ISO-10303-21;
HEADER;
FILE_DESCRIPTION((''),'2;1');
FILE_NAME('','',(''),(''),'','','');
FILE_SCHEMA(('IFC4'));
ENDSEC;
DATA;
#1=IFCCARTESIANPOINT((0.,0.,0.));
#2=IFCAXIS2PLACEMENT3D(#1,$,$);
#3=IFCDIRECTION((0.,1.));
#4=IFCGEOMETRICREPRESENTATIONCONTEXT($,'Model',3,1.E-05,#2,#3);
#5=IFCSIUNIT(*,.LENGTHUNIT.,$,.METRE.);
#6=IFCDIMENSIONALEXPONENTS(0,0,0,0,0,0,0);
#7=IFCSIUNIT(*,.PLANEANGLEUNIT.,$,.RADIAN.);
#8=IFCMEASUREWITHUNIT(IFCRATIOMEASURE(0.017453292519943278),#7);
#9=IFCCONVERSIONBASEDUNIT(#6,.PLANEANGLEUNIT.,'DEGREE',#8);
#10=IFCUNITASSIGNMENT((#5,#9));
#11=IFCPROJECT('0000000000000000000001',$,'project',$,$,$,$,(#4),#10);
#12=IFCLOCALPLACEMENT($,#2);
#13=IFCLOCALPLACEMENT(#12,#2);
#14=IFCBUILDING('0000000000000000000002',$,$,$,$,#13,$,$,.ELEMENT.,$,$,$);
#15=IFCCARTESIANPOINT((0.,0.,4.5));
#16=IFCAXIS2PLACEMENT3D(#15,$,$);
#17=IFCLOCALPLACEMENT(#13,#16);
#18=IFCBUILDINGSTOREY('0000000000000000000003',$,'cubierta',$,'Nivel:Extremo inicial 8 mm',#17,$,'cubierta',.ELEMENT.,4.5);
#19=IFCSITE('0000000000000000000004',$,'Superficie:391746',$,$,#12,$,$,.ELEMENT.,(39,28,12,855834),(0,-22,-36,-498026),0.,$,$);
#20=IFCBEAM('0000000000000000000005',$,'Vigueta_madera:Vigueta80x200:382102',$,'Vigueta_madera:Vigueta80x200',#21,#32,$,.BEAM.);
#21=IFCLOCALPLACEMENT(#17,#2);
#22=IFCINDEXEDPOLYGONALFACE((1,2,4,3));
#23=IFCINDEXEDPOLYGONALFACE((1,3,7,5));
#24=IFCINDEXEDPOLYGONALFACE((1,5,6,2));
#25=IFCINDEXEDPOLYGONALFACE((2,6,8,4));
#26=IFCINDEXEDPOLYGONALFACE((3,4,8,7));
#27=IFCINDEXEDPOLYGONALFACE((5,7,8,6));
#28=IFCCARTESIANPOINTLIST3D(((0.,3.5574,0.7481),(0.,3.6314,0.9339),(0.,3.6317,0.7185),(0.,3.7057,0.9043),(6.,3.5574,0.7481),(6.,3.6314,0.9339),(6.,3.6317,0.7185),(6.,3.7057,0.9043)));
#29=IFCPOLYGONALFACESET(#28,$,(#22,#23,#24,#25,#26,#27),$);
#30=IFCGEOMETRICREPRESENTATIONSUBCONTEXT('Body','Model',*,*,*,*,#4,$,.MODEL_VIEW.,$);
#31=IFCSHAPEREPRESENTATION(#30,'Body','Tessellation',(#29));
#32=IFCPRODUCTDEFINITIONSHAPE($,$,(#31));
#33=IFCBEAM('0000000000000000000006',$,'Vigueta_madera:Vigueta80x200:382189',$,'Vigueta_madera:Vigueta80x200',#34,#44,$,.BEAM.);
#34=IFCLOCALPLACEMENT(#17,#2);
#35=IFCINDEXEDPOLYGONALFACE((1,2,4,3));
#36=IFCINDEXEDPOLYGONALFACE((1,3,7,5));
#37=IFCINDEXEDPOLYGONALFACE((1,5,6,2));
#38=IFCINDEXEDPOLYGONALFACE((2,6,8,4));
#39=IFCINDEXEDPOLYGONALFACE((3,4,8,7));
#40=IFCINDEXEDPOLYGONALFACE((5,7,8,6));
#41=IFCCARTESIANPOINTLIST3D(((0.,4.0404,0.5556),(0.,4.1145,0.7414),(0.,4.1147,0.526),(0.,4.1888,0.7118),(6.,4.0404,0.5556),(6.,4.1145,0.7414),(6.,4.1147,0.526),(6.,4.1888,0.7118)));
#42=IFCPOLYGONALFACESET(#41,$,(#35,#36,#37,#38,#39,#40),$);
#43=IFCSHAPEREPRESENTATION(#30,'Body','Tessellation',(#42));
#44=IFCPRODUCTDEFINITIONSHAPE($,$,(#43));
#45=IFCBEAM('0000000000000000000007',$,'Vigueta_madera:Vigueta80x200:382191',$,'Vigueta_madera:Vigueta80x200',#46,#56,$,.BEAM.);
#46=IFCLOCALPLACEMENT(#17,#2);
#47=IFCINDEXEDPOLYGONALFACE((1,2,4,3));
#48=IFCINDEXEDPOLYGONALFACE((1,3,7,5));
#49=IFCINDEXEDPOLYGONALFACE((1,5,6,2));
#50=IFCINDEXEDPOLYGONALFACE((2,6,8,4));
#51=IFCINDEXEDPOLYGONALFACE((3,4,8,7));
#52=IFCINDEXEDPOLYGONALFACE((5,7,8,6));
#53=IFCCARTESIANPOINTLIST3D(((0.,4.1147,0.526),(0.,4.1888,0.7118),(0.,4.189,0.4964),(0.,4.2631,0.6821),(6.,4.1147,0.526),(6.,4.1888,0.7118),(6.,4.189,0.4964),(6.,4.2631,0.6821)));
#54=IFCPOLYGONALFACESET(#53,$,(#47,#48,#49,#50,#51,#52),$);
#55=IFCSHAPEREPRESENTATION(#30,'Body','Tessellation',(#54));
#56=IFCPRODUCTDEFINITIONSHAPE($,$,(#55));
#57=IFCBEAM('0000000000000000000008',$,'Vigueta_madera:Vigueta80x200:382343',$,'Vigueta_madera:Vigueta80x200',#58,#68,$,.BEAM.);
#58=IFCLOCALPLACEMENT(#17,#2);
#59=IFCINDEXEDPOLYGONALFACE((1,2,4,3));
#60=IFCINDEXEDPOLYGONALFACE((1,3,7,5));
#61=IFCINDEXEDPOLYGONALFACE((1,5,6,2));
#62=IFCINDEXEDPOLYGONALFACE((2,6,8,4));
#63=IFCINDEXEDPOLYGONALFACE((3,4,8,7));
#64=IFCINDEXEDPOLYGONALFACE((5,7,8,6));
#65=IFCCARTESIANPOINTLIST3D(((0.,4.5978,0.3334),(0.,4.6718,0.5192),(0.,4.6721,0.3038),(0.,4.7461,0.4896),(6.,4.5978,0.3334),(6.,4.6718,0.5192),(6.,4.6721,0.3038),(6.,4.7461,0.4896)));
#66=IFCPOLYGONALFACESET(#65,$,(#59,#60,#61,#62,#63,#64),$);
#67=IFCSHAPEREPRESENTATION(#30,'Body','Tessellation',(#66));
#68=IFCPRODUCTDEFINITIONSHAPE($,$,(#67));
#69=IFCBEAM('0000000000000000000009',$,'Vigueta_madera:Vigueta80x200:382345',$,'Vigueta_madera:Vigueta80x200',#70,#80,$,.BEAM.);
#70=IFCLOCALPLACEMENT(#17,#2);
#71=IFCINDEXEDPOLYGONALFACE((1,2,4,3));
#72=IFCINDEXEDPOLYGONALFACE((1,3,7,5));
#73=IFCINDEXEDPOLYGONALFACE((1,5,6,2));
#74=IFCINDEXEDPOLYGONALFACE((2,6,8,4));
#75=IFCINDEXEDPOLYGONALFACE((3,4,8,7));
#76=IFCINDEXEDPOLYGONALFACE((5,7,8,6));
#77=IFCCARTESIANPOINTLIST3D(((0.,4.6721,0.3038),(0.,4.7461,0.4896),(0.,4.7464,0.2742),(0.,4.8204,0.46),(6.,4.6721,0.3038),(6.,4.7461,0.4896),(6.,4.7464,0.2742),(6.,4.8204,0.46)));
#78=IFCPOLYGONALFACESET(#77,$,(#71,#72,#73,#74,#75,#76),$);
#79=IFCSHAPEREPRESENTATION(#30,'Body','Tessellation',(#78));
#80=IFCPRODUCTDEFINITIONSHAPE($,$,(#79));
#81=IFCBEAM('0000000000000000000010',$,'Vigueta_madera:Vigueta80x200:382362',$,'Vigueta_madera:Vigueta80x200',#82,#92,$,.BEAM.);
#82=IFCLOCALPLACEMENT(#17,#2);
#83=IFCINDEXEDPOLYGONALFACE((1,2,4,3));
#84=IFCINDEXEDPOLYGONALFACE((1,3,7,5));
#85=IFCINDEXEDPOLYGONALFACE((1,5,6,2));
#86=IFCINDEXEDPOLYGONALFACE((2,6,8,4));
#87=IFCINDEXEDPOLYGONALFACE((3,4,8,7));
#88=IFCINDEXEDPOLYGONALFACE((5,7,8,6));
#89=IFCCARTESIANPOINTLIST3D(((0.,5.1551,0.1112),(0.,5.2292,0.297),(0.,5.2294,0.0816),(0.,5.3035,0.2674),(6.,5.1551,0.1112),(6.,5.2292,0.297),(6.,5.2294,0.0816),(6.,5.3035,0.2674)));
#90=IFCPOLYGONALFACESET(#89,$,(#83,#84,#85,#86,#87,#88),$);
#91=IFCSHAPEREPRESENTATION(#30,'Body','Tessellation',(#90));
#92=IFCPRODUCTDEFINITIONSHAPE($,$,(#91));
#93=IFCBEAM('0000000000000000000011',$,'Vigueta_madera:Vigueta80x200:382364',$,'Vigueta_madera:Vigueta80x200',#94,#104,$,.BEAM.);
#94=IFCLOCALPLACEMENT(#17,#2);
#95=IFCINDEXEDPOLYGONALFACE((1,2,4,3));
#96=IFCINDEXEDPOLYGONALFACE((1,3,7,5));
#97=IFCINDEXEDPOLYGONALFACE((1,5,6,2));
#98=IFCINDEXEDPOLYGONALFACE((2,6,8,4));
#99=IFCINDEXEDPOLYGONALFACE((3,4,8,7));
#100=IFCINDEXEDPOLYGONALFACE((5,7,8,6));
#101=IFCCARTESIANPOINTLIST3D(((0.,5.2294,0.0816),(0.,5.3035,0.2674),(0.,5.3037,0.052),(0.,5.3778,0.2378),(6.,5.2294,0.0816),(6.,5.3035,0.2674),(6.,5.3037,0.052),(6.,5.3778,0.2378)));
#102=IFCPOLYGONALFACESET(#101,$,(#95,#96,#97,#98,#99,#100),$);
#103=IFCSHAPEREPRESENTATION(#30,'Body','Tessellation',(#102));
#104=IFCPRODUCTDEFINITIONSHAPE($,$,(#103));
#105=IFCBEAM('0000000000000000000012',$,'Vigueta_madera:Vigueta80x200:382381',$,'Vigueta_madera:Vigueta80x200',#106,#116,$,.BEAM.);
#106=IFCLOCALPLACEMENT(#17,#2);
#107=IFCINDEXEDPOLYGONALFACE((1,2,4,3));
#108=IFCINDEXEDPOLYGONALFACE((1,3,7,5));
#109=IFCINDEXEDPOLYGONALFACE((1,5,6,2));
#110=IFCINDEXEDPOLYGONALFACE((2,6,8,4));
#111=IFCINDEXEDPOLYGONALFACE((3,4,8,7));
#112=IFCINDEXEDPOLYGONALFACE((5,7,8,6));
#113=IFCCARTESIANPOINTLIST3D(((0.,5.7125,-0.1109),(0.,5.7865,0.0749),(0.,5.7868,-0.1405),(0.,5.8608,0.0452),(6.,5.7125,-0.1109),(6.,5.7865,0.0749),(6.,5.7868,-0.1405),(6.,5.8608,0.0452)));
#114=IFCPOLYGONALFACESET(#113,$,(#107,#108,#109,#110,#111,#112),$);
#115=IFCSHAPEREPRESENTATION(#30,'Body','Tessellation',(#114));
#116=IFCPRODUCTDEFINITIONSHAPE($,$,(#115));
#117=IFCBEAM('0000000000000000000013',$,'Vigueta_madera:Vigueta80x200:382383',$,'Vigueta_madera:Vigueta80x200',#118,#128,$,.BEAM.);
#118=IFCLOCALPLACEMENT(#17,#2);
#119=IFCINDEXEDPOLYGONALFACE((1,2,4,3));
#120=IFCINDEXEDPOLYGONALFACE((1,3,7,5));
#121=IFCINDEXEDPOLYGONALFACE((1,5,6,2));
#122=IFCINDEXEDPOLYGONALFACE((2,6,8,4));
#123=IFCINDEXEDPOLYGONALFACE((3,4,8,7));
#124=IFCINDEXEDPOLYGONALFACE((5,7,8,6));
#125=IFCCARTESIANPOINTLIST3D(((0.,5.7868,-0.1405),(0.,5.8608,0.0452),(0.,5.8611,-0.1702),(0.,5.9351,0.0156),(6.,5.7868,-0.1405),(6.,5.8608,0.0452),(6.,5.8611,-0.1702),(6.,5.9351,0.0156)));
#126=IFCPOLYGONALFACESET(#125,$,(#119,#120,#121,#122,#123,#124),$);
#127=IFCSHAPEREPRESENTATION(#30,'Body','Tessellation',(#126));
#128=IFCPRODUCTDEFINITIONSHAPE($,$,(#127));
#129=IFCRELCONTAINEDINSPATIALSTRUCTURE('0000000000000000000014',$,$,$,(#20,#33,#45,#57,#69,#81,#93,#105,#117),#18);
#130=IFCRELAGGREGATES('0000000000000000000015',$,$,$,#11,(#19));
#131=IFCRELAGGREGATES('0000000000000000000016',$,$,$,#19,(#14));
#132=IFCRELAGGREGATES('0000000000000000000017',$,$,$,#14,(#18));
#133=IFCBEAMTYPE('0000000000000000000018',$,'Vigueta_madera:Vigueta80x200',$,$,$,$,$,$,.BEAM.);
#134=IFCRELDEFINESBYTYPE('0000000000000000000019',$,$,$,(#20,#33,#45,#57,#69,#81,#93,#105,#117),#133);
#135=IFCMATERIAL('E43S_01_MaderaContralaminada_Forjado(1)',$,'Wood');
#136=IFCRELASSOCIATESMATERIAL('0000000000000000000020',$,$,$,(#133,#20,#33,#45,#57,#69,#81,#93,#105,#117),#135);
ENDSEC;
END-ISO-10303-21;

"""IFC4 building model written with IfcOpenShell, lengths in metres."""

from ifc_helpers import new_model, entity, si_unit, converted_unit, direction, frame, frame_2d, origin, place, context, subcontext, project, spatial, polyline, segment, composite_curve, rectangle, outline, extrude, source, transform, mapped, material, material_profile, profile_set, profile_usage, type_object, type_shapes, element, save


model = new_model("IFC4")

# Units and contexts
model_context = context("Model", 3, precision=1e-05, world=origin(), true_north=direction((0.0, 1.0)))
body_context = subcontext(model_context, "Body", "Model", "MODEL_VIEW")
ifc_project = project(units=[si_unit("LENGTHUNIT", "METRE"), converted_unit("PLANEANGLEUNIT", "DEGREE", entity("IfcRatioMeasure", 0.017453292519943278), si_unit("PLANEANGLEUNIT", "RADIAN"), dimensions=[0, 0, 0, 0, 0, 0, 0])], contexts=[model_context])

# Site, building, storey
site_placement = place(None, origin())
site = spatial("IfcSite", under=ifc_project, at=site_placement, Name="Superficie:391746", CompositionType="ELEMENT", RefLatitude=(39, 28, 12, 855834), RefLongitude=(0, -22, -36, -498026), RefElevation=0.0)
building_placement = place(site_placement, origin())
building = spatial("IfcBuilding", under=site, at=building_placement, CompositionType="ELEMENT")
storey_placement = place(building_placement, frame((0.0, 0.0, 4.5)))
storey = spatial("IfcBuildingStorey", under=building, at=storey_placement, Name="cubierta", ObjectType="Nivel:Extremo inicial 8 mm", LongName="cubierta", CompositionType="ELEMENT", Elevation=4.5)

# Beams
ifc_material = material(Name="E43S_01_MaderaContralaminada_Forjado(1)", Category="Wood")
ifc_material_profile_1 = material_profile(ifc_material, outline(composite_curve([segment(polyline([(0.04, 0.1, 0.0), (0.04, -0.1, 0.0)]), True, "CONTINUOUS"), segment(polyline([(0.04, -0.1, 0.0), (-0.04, -0.1, 0.0)]), True, "CONTINUOUS"), segment(polyline([(-0.04, -0.1, 0.0), (-0.04, 0.1, 0.0)]), True, "CONTINUOUS"), segment(polyline([(-0.04, 0.1, 0.0), (0.04, 0.1, 0.0)]), True, "CONTINUOUS")], self_intersect=False), kind="CURVE"), Name="Vigueta80x200")
ifc_material_profile_2 = material_profile(ifc_material, outline(composite_curve([segment(polyline([(-3.0, 0.04, 0.1), (-3.0, 0.04, -0.1)]), True, "CONTINUOUS"), segment(polyline([(-3.0, 0.04, -0.1), (-3.0, -0.04, -0.1)]), True, "CONTINUOUS"), segment(polyline([(-3.0, -0.04, -0.1), (-3.0, -0.04, 0.1)]), True, "CONTINUOUS"), segment(polyline([(-3.0, -0.04, 0.1), (-3.0, 0.04, 0.1)]), True, "CONTINUOUS")], self_intersect=False), kind="CURVE"), Name="Vigueta80x200")
ifc_profile_set = profile_set([ifc_material_profile_1, ifc_material_profile_2], Name="Vigueta80x200")
beam_type_1 = type_object("IfcBeamType", Name="Vigueta_madera:Vigueta80x200", PredefinedType="BEAM", material=ifc_profile_set)
shared_shape_1 = source(origin(), body_context, "Body", "SweptSolid", [
    extrude(rectangle(XDim=0.2, YDim=0.08, at=frame_2d((0.0, 0.0), x_axis=(1.0, 0.0))), frame((-3.0, 0.0, 0.0), z_axis=(1.0, 0.0, 0.0), x_axis=(0.0, 0.0, -1.0)), (0.0, 0.0, 1.0), 6.0),
])
type_shapes(beam_type_1, [shared_shape_1])
ifc_profile_usage_1 = profile_usage(ifc_profile_set, cardinal=8)
beam_1_placement = place(storey_placement, frame((3.0, 3.6315, 0.8262), z_axis=(0.0, 0.370233, 0.928939), x_axis=(1.0, 0.0, 0.0)))
element("IfcBeam", 1, at=beam_1_placement, inside=storey, type_object=beam_type_1, material=ifc_profile_usage_1, Name="Vigueta_madera:Vigueta80x200:382102", ObjectType="Vigueta_madera:Vigueta80x200", PredefinedType="BEAM", context=body_context, shape_type="MappedRepresentation", body=[
    mapped(shared_shape_1, transform((0.0, 0.0, 0.0), scale=1.0)),
])
ifc_profile_usage_2 = profile_usage(ifc_profile_set, cardinal=8)
beam_2_placement = place(storey_placement, frame((3.0, 4.1146, 0.6337), z_axis=(0.0, 0.370233, 0.928939), x_axis=(1.0, 0.0, 0.0)))
element("IfcBeam", 2, at=beam_2_placement, inside=storey, type_object=beam_type_1, material=ifc_profile_usage_2, Name="Vigueta_madera:Vigueta80x200:382189", ObjectType="Vigueta_madera:Vigueta80x200", PredefinedType="BEAM", context=body_context, shape_type="MappedRepresentation", body=[
    mapped(shared_shape_1, transform((0.0, 0.0, 0.0), scale=1.0)),
])
ifc_profile_usage_3 = profile_usage(ifc_profile_set, cardinal=8)
beam_3_placement = place(storey_placement, frame((3.0, 4.1889, 0.6041), z_axis=(0.0, 0.370233, 0.928939), x_axis=(1.0, 0.0, 0.0)))
element("IfcBeam", 3, at=beam_3_placement, inside=storey, type_object=beam_type_1, material=ifc_profile_usage_3, Name="Vigueta_madera:Vigueta80x200:382191", ObjectType="Vigueta_madera:Vigueta80x200", PredefinedType="BEAM", context=body_context, shape_type="MappedRepresentation", body=[
    mapped(shared_shape_1, transform((0.0, 0.0, 0.0), scale=1.0)),
])
ifc_profile_usage_4 = profile_usage(ifc_profile_set, cardinal=8)
beam_4_placement = place(storey_placement, frame((3.0, 4.6719, 0.4115), z_axis=(0.0, 0.370233, 0.928939), x_axis=(1.0, 0.0, 0.0)))
element("IfcBeam", 4, at=beam_4_placement, inside=storey, type_object=beam_type_1, material=ifc_profile_usage_4, Name="Vigueta_madera:Vigueta80x200:382343", ObjectType="Vigueta_madera:Vigueta80x200", PredefinedType="BEAM", context=body_context, shape_type="MappedRepresentation", body=[
    mapped(shared_shape_1, transform((0.0, 0.0, 0.0), scale=1.0)),
])
ifc_profile_usage_5 = profile_usage(ifc_profile_set, cardinal=8)
beam_5_placement = place(storey_placement, frame((3.0, 4.7463, 0.3819), z_axis=(0.0, 0.370233, 0.928939), x_axis=(1.0, 0.0, 0.0)))
element("IfcBeam", 5, at=beam_5_placement, inside=storey, type_object=beam_type_1, material=ifc_profile_usage_5, Name="Vigueta_madera:Vigueta80x200:382345", ObjectType="Vigueta_madera:Vigueta80x200", PredefinedType="BEAM", context=body_context, shape_type="MappedRepresentation", body=[
    mapped(shared_shape_1, transform((0.0, 0.0, 0.0), scale=1.0)),
])
ifc_profile_usage_6 = profile_usage(ifc_profile_set, cardinal=8)
beam_6_placement = place(storey_placement, frame((3.0, 5.2293, 0.1893), z_axis=(0.0, 0.370233, 0.928939), x_axis=(1.0, 0.0, 0.0)))
element("IfcBeam", 6, at=beam_6_placement, inside=storey, type_object=beam_type_1, material=ifc_profile_usage_6, Name="Vigueta_madera:Vigueta80x200:382362", ObjectType="Vigueta_madera:Vigueta80x200", PredefinedType="BEAM", context=body_context, shape_type="MappedRepresentation", body=[
    mapped(shared_shape_1, transform((0.0, 0.0, 0.0), scale=1.0)),
])
ifc_profile_usage_7 = profile_usage(ifc_profile_set, cardinal=8)
beam_7_placement = place(storey_placement, frame((3.0, 5.3036, 0.1597), z_axis=(0.0, 0.370233, 0.928939), x_axis=(1.0, 0.0, 0.0)))
element("IfcBeam", 7, at=beam_7_placement, inside=storey, type_object=beam_type_1, material=ifc_profile_usage_7, Name="Vigueta_madera:Vigueta80x200:382364", ObjectType="Vigueta_madera:Vigueta80x200", PredefinedType="BEAM", context=body_context, shape_type="MappedRepresentation", body=[
    mapped(shared_shape_1, transform((0.0, 0.0, 0.0), scale=1.0)),
])
ifc_profile_usage_8 = profile_usage(ifc_profile_set, cardinal=8)
beam_8_placement = place(storey_placement, frame((3.0, 5.7866, -0.0328), z_axis=(0.0, 0.370233, 0.928939), x_axis=(1.0, 0.0, 0.0)))
element("IfcBeam", 8, at=beam_8_placement, inside=storey, type_object=beam_type_1, material=ifc_profile_usage_8, Name="Vigueta_madera:Vigueta80x200:382381", ObjectType="Vigueta_madera:Vigueta80x200", PredefinedType="BEAM", context=body_context, shape_type="MappedRepresentation", body=[
    mapped(shared_shape_1, transform((0.0, 0.0, 0.0), scale=1.0)),
])
ifc_profile_usage_9 = profile_usage(ifc_profile_set, cardinal=8)
beam_9_placement = place(storey_placement, frame((3.0, 5.861, -0.0625), z_axis=(0.0, 0.370233, 0.928939), x_axis=(1.0, 0.0, 0.0)))
element("IfcBeam", 9, at=beam_9_placement, inside=storey, type_object=beam_type_1, material=ifc_profile_usage_9, Name="Vigueta_madera:Vigueta80x200:382383", ObjectType="Vigueta_madera:Vigueta80x200", PredefinedType="BEAM", context=body_context, shape_type="MappedRepresentation", body=[
    mapped(shared_shape_1, transform((0.0, 0.0, 0.0), scale=1.0)),
])

save(model, "model.ifc")
